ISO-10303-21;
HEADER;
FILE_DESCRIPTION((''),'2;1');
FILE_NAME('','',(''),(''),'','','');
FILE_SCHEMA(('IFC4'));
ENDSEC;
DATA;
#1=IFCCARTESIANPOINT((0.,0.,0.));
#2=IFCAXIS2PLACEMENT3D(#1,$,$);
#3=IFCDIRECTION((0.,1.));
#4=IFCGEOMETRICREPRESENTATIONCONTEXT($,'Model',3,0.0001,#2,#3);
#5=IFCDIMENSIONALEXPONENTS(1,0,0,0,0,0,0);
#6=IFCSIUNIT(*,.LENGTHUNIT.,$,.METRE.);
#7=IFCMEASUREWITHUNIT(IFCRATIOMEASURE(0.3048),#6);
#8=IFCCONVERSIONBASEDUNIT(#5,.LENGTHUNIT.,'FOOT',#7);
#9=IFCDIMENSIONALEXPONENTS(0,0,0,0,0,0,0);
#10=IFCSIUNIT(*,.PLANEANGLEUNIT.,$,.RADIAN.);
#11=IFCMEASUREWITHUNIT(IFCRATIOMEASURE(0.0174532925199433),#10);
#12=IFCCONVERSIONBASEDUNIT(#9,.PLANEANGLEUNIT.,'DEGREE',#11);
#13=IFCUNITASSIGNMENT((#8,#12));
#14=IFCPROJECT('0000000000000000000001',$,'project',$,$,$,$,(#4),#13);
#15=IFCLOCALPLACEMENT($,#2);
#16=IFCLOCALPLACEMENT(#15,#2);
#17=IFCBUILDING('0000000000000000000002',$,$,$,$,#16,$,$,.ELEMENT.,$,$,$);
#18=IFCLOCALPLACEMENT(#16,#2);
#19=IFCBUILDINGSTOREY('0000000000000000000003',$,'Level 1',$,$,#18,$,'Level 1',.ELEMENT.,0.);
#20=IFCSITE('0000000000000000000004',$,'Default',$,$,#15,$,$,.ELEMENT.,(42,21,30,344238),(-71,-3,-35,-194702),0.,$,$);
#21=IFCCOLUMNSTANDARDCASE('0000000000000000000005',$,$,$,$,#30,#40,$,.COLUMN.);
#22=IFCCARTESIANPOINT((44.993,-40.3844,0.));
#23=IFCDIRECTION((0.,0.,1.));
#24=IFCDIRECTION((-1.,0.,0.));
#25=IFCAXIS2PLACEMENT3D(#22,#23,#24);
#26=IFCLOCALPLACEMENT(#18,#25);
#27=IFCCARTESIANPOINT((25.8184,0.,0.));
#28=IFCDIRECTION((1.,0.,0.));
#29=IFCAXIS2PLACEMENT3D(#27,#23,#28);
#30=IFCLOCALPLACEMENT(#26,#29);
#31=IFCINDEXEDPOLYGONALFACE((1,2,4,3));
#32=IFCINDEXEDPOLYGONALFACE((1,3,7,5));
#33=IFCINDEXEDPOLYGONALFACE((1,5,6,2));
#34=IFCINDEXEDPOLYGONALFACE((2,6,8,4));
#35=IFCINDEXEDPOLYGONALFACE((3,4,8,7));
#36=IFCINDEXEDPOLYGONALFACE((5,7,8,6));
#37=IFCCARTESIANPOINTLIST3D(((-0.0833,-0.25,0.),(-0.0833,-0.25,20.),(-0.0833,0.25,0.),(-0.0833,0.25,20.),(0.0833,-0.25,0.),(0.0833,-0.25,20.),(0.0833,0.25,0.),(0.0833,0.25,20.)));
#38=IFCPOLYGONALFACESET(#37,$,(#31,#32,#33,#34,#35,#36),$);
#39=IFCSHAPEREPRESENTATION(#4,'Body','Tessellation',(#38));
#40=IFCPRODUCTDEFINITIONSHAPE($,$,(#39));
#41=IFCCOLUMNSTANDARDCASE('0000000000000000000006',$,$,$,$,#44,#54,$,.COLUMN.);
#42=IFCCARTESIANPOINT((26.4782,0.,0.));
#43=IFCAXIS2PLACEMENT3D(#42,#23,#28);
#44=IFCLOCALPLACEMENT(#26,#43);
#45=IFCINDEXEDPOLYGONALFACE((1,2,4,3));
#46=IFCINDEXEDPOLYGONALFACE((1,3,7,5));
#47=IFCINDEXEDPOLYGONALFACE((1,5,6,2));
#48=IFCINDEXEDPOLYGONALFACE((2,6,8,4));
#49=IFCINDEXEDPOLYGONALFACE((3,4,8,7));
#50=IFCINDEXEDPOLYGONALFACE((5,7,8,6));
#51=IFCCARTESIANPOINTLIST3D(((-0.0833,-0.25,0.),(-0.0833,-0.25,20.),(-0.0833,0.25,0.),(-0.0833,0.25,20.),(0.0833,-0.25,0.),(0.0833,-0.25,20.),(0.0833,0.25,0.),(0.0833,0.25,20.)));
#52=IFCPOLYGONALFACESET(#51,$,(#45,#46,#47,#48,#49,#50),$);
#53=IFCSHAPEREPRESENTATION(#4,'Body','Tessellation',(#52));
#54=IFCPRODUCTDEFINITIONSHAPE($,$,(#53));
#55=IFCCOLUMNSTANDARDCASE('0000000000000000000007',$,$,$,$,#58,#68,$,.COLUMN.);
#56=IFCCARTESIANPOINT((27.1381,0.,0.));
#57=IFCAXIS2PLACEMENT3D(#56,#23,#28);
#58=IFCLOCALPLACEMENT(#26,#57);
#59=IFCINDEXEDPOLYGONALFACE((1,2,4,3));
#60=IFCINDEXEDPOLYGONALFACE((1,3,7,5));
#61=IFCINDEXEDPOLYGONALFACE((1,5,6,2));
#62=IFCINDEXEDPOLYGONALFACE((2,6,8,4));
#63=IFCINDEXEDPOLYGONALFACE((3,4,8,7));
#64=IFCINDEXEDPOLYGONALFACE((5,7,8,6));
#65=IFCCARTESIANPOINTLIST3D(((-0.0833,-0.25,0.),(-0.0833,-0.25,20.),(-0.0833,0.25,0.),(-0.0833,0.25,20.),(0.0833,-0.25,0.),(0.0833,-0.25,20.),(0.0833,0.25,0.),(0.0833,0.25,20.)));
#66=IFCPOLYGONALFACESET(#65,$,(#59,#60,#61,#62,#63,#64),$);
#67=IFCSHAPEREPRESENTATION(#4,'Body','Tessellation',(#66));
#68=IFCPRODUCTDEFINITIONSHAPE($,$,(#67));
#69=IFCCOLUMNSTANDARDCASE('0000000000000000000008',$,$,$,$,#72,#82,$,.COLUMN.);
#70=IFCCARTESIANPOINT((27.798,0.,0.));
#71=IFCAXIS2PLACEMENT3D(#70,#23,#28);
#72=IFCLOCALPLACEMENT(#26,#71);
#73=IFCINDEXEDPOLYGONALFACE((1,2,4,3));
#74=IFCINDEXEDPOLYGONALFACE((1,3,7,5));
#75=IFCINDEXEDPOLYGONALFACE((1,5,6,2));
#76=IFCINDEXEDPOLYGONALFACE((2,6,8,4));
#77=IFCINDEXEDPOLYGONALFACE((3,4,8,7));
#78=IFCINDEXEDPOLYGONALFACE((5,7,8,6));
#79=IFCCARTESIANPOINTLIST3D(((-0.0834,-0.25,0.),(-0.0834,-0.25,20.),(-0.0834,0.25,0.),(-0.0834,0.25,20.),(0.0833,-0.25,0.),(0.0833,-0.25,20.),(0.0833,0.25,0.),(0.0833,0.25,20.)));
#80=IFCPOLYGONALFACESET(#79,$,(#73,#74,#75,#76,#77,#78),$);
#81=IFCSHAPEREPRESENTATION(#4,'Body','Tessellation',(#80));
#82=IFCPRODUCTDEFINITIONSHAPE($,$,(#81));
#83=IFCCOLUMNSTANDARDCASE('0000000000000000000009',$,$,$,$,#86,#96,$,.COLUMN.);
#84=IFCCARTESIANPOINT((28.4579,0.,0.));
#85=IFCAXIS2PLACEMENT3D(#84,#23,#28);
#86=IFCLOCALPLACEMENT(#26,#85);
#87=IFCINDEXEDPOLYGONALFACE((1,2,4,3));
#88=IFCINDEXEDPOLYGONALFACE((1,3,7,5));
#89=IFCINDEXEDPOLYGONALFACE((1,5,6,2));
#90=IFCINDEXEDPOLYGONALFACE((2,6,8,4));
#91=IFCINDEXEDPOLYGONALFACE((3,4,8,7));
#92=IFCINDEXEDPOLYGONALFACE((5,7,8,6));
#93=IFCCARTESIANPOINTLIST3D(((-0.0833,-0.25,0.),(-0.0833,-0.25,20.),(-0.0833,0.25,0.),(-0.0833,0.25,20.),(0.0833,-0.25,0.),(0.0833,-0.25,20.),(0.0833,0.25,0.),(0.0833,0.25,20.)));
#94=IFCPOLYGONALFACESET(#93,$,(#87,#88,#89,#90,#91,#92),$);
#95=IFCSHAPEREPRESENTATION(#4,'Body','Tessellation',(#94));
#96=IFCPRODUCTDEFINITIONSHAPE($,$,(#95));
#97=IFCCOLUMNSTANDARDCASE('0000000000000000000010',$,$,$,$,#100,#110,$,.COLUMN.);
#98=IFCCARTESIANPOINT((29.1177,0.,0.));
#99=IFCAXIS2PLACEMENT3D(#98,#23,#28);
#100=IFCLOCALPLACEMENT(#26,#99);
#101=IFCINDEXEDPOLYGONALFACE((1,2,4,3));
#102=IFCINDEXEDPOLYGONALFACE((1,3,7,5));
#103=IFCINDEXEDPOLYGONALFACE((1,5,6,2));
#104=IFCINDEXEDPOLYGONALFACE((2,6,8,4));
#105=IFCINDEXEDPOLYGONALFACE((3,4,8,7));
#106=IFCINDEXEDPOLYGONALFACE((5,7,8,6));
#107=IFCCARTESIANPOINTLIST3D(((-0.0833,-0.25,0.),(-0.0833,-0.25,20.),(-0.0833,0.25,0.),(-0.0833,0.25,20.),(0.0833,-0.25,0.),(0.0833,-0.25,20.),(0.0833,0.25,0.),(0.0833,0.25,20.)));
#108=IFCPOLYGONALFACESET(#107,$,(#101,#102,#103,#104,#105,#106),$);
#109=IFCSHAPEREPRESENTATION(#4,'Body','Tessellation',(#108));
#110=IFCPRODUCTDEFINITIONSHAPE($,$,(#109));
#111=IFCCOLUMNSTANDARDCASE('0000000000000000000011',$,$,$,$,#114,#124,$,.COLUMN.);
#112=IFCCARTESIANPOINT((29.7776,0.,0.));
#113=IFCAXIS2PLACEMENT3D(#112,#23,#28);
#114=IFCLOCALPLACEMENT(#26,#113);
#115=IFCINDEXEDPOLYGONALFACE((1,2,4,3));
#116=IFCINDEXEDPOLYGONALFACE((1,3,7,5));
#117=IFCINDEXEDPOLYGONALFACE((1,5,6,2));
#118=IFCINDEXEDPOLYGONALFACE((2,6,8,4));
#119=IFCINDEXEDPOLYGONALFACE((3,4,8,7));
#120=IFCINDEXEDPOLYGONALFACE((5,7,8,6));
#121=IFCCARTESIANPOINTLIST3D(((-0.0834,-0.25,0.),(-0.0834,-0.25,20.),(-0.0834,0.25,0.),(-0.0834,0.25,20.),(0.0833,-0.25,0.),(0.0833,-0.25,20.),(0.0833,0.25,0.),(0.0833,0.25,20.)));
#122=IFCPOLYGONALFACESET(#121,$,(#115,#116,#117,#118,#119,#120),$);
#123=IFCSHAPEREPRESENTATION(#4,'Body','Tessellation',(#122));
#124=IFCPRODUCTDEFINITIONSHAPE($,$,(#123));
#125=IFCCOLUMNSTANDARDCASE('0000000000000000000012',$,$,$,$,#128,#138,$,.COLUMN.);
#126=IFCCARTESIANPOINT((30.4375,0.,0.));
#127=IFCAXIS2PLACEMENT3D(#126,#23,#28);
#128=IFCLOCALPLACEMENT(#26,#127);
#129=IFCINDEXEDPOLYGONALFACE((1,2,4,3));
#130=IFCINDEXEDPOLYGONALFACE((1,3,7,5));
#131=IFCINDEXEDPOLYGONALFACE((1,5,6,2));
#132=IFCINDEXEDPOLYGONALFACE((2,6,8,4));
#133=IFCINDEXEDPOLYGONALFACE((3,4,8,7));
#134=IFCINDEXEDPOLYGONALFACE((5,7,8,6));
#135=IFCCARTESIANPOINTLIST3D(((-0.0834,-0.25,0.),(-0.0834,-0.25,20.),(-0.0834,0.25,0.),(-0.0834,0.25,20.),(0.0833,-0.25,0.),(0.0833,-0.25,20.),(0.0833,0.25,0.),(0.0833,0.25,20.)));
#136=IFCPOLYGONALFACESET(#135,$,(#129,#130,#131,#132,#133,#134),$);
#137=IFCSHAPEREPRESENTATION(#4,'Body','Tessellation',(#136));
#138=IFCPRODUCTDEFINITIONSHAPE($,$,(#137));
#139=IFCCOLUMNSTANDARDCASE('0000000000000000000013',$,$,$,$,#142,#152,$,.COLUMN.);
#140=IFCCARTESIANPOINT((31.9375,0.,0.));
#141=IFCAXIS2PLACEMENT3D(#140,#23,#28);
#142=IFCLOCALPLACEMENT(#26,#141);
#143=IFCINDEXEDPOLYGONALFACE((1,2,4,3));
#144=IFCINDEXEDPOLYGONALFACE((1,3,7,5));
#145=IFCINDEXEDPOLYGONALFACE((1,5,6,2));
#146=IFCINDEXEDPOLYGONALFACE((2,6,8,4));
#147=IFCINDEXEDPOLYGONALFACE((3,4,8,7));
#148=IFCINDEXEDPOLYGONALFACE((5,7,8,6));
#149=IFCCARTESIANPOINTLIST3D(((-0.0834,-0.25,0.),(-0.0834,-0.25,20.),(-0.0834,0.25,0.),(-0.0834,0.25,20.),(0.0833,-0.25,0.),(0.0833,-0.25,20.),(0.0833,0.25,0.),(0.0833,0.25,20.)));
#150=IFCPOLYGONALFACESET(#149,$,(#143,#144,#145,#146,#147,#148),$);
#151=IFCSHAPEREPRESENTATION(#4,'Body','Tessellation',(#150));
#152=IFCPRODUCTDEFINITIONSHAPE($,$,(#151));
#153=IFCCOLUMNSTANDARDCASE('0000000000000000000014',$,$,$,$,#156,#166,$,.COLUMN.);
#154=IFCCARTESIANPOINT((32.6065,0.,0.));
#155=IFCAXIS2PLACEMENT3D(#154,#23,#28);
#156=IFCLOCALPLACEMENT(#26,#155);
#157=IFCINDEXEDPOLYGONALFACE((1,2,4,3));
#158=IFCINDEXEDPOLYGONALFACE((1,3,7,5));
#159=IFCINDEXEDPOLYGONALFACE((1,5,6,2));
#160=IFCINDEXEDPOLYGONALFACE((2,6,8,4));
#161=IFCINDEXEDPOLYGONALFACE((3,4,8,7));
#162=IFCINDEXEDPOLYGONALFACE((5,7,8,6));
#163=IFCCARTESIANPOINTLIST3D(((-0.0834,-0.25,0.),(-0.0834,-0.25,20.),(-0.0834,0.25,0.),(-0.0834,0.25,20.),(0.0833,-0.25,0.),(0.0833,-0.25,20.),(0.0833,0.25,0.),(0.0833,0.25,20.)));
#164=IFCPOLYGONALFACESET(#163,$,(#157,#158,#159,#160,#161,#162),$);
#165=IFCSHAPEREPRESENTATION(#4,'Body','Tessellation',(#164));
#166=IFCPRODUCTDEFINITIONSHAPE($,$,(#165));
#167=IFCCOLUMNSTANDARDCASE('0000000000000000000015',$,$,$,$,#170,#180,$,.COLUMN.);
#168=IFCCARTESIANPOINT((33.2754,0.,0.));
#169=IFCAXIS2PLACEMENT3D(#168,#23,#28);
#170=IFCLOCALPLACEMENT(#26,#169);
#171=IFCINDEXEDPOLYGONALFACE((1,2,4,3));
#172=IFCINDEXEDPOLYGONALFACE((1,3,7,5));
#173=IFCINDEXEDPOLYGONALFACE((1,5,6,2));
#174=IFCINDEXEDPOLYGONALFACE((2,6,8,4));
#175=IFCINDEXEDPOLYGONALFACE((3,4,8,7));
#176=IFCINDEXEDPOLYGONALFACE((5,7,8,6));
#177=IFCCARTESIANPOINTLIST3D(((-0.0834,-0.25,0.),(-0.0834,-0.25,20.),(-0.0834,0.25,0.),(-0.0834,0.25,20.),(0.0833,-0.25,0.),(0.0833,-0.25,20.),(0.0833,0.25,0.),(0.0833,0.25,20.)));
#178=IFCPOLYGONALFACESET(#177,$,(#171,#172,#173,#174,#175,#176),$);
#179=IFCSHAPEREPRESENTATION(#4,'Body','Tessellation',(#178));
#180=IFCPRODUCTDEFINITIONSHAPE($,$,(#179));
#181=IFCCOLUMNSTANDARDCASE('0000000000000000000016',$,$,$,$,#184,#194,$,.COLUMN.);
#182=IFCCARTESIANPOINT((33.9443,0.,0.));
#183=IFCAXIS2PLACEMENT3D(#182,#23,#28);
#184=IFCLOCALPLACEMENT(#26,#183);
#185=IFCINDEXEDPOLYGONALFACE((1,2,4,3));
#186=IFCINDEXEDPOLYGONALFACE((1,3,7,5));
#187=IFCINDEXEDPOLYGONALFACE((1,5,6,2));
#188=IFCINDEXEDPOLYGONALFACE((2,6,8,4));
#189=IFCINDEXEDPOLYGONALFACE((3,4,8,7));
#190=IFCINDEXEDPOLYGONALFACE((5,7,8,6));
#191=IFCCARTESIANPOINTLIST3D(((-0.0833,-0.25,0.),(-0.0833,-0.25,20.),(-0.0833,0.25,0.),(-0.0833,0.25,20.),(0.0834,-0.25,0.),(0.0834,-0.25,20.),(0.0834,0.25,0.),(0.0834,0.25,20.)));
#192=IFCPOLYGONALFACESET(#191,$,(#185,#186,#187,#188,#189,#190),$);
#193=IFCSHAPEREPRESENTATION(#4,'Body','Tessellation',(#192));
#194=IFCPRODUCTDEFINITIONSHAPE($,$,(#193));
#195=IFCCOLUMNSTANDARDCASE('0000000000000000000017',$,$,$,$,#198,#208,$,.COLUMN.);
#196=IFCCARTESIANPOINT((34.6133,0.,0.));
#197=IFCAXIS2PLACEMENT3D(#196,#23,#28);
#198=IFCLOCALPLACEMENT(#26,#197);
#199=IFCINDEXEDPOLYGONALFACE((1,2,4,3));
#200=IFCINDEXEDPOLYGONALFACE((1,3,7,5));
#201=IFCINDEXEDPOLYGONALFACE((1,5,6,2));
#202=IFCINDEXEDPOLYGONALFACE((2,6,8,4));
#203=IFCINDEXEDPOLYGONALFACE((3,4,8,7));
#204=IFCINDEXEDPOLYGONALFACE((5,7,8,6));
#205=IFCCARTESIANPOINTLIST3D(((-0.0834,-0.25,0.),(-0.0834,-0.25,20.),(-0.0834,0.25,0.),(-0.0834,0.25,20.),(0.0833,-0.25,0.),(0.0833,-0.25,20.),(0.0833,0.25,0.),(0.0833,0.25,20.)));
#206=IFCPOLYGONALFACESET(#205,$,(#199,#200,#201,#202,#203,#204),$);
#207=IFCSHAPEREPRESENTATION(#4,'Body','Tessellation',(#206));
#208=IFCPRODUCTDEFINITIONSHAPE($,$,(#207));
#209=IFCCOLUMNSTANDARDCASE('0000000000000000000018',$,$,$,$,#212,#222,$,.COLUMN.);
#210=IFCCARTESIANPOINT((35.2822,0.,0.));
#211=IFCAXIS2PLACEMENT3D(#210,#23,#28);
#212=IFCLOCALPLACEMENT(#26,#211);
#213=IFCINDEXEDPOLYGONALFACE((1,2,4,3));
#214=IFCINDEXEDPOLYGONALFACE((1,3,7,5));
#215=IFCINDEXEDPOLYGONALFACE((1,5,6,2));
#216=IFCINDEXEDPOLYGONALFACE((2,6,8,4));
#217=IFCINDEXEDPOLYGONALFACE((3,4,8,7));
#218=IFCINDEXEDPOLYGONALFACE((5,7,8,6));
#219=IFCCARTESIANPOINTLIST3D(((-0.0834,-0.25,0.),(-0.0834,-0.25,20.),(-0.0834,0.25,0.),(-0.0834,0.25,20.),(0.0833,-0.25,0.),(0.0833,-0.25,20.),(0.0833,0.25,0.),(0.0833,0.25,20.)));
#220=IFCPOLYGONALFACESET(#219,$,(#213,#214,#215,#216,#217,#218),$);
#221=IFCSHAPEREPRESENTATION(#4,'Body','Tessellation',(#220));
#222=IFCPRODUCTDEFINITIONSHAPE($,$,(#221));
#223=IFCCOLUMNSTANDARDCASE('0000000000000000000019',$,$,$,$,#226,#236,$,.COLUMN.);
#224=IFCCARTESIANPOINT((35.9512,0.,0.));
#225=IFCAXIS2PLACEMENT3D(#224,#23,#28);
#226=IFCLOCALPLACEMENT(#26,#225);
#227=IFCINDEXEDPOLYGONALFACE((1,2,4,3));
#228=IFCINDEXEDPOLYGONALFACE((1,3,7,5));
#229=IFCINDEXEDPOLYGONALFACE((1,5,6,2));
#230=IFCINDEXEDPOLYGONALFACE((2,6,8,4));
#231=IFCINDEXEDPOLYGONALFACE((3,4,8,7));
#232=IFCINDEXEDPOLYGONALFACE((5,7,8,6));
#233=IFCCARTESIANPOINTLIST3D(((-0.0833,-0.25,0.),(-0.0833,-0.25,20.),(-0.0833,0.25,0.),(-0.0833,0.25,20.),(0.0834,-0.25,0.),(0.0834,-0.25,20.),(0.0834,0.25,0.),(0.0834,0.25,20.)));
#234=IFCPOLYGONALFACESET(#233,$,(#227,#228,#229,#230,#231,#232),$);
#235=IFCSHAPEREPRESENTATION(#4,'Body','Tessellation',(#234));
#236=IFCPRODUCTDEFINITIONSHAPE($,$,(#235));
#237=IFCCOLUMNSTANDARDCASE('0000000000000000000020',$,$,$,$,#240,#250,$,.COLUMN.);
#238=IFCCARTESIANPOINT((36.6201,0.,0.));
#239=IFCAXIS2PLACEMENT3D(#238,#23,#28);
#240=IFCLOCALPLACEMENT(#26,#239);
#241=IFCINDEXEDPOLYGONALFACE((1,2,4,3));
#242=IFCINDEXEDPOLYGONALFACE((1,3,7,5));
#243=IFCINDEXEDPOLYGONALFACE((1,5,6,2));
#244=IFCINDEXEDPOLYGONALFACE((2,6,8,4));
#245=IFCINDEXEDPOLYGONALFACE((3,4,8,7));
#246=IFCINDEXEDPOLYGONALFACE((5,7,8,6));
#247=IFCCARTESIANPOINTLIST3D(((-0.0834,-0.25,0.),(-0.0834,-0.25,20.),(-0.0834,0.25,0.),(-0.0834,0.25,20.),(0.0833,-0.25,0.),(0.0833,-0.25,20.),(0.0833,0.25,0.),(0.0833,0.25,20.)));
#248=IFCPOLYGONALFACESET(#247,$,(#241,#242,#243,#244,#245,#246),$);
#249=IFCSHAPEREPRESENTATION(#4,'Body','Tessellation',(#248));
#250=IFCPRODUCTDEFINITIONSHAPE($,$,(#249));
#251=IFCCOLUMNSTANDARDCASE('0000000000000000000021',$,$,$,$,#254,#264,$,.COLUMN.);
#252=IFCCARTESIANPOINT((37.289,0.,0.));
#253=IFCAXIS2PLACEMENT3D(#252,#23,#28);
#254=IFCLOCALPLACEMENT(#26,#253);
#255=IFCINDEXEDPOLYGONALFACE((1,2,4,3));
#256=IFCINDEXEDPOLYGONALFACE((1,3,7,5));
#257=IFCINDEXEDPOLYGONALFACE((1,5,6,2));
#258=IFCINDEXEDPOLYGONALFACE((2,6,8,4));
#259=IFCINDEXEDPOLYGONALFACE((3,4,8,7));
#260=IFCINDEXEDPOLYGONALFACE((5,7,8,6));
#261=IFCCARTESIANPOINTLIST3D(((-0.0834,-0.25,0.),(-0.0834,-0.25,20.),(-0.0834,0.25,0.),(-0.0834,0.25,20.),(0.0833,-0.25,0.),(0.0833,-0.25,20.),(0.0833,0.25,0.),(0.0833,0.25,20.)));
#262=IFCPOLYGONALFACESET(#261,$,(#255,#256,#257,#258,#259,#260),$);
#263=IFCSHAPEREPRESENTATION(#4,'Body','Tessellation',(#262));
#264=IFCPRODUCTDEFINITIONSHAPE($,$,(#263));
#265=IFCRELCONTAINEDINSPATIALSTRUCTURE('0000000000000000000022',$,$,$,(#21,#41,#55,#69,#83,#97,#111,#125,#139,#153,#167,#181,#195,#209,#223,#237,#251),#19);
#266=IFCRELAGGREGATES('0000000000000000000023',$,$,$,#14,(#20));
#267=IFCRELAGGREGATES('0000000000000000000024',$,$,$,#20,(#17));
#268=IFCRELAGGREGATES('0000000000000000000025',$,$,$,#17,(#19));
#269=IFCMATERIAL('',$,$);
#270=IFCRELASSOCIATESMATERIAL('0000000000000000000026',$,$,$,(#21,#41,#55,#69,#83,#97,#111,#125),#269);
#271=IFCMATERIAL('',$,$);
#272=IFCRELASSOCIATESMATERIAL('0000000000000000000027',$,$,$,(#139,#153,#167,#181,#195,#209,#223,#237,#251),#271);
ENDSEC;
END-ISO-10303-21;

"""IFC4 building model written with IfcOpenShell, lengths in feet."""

from ifc_helpers import new_model, entity, si_unit, converted_unit, direction, frame, origin, place, context, project, spatial, rectangle, extrude, material, element, save


model = new_model("IFC4")

# Units and contexts
model_context = context("Model", 3, precision=0.0001, world=origin(), true_north=direction((0.0, 1.0)))
ifc_project = project(units=[converted_unit("LENGTHUNIT", "FOOT", entity("IfcRatioMeasure", 0.3048), si_unit("LENGTHUNIT", "METRE"), dimensions=[1, 0, 0, 0, 0, 0, 0]), converted_unit("PLANEANGLEUNIT", "DEGREE", entity("IfcRatioMeasure", 0.0174532925199433), si_unit("PLANEANGLEUNIT", "RADIAN"), dimensions=[0, 0, 0, 0, 0, 0, 0])], contexts=[model_context])

# Site, building, storey
site_placement = place(None, origin())
site = spatial("IfcSite", under=ifc_project, at=site_placement, Name="Default", CompositionType="ELEMENT", RefLatitude=(42, 21, 30, 344238), RefLongitude=(-71, -3, -35, -194702), RefElevation=0.0)
building_placement = place(site_placement, origin())
building = spatial("IfcBuilding", under=site, at=building_placement, CompositionType="ELEMENT")
storey_placement = place(building_placement, origin())
storey = spatial("IfcBuildingStorey", under=building, at=storey_placement, Name="Level 1", LongName="Level 1", CompositionType="ELEMENT", Elevation=0.0)

# Columns
ifc_material_1 = material(Name="")
placement = place(storey_placement, frame((44.993, -40.3844, 0.0), z_axis=(0.0, 0.0, 1.0), x_axis=(-1.0, 0.0, 0.0)))
for number, where, z_axis, x_axis in (
    (1, (25.8184, 0.0, 0.0), (0.0, 0.0, 1.0), (1.0, 0.0, 0.0)),
    (2, (26.4782, 0.0, 0.0), (0.0, 0.0, 1.0), (1.0, 0.0, 0.0)),
    (3, (27.1381, 0.0, 0.0), (0.0, 0.0, 1.0), (1.0, 0.0, 0.0)),
    (4, (27.798, 0.0, 0.0), (0.0, 0.0, 1.0), (1.0, 0.0, 0.0)),
    (5, (28.4579, 0.0, 0.0), (0.0, 0.0, 1.0), (1.0, 0.0, 0.0)),
    (6, (29.1177, 0.0, 0.0), (0.0, 0.0, 1.0), (1.0, 0.0, 0.0)),
    (7, (29.7776, 0.0, 0.0), (0.0, 0.0, 1.0), (1.0, 0.0, 0.0)),
    (8, (30.4375, 0.0, 0.0), (0.0, 0.0, 1.0), (1.0, 0.0, 0.0)),
):
    element("IfcColumnStandardCase", number, at=place(placement, frame(where, z_axis=z_axis, x_axis=x_axis)), inside=storey, material=ifc_material_1, PredefinedType="COLUMN", context=model_context, shape_type="SweptSolid", body=[
        extrude(rectangle(XDim=0.1667, YDim=0.5), origin(), (0.0, 0.0, 1.0), 20.0),
    ])
ifc_material_2 = material(Name="")
for number, where, z_axis, x_axis in (
    (9, (31.9375, 0.0, 0.0), (0.0, 0.0, 1.0), (1.0, 0.0, 0.0)),
    (10, (32.6065, 0.0, 0.0), (0.0, 0.0, 1.0), (1.0, 0.0, 0.0)),
    (11, (33.2754, 0.0, 0.0), (0.0, 0.0, 1.0), (1.0, 0.0, 0.0)),
    (12, (33.9443, 0.0, 0.0), (0.0, 0.0, 1.0), (1.0, 0.0, 0.0)),
    (13, (34.6133, 0.0, 0.0), (0.0, 0.0, 1.0), (1.0, 0.0, 0.0)),
    (14, (35.2822, 0.0, 0.0), (0.0, 0.0, 1.0), (1.0, 0.0, 0.0)),
    (15, (35.9512, 0.0, 0.0), (0.0, 0.0, 1.0), (1.0, 0.0, 0.0)),
    (16, (36.6201, 0.0, 0.0), (0.0, 0.0, 1.0), (1.0, 0.0, 0.0)),
    (17, (37.289, 0.0, 0.0), (0.0, 0.0, 1.0), (1.0, 0.0, 0.0)),
):
    element("IfcColumnStandardCase", number, at=place(placement, frame(where, z_axis=z_axis, x_axis=x_axis)), inside=storey, material=ifc_material_2, PredefinedType="COLUMN", context=model_context, shape_type="SweptSolid", body=[
        extrude(rectangle(XDim=0.1667, YDim=0.5), origin(), (0.0, 0.0, 1.0), 20.0),
    ])

save(model, "model.ifc")
